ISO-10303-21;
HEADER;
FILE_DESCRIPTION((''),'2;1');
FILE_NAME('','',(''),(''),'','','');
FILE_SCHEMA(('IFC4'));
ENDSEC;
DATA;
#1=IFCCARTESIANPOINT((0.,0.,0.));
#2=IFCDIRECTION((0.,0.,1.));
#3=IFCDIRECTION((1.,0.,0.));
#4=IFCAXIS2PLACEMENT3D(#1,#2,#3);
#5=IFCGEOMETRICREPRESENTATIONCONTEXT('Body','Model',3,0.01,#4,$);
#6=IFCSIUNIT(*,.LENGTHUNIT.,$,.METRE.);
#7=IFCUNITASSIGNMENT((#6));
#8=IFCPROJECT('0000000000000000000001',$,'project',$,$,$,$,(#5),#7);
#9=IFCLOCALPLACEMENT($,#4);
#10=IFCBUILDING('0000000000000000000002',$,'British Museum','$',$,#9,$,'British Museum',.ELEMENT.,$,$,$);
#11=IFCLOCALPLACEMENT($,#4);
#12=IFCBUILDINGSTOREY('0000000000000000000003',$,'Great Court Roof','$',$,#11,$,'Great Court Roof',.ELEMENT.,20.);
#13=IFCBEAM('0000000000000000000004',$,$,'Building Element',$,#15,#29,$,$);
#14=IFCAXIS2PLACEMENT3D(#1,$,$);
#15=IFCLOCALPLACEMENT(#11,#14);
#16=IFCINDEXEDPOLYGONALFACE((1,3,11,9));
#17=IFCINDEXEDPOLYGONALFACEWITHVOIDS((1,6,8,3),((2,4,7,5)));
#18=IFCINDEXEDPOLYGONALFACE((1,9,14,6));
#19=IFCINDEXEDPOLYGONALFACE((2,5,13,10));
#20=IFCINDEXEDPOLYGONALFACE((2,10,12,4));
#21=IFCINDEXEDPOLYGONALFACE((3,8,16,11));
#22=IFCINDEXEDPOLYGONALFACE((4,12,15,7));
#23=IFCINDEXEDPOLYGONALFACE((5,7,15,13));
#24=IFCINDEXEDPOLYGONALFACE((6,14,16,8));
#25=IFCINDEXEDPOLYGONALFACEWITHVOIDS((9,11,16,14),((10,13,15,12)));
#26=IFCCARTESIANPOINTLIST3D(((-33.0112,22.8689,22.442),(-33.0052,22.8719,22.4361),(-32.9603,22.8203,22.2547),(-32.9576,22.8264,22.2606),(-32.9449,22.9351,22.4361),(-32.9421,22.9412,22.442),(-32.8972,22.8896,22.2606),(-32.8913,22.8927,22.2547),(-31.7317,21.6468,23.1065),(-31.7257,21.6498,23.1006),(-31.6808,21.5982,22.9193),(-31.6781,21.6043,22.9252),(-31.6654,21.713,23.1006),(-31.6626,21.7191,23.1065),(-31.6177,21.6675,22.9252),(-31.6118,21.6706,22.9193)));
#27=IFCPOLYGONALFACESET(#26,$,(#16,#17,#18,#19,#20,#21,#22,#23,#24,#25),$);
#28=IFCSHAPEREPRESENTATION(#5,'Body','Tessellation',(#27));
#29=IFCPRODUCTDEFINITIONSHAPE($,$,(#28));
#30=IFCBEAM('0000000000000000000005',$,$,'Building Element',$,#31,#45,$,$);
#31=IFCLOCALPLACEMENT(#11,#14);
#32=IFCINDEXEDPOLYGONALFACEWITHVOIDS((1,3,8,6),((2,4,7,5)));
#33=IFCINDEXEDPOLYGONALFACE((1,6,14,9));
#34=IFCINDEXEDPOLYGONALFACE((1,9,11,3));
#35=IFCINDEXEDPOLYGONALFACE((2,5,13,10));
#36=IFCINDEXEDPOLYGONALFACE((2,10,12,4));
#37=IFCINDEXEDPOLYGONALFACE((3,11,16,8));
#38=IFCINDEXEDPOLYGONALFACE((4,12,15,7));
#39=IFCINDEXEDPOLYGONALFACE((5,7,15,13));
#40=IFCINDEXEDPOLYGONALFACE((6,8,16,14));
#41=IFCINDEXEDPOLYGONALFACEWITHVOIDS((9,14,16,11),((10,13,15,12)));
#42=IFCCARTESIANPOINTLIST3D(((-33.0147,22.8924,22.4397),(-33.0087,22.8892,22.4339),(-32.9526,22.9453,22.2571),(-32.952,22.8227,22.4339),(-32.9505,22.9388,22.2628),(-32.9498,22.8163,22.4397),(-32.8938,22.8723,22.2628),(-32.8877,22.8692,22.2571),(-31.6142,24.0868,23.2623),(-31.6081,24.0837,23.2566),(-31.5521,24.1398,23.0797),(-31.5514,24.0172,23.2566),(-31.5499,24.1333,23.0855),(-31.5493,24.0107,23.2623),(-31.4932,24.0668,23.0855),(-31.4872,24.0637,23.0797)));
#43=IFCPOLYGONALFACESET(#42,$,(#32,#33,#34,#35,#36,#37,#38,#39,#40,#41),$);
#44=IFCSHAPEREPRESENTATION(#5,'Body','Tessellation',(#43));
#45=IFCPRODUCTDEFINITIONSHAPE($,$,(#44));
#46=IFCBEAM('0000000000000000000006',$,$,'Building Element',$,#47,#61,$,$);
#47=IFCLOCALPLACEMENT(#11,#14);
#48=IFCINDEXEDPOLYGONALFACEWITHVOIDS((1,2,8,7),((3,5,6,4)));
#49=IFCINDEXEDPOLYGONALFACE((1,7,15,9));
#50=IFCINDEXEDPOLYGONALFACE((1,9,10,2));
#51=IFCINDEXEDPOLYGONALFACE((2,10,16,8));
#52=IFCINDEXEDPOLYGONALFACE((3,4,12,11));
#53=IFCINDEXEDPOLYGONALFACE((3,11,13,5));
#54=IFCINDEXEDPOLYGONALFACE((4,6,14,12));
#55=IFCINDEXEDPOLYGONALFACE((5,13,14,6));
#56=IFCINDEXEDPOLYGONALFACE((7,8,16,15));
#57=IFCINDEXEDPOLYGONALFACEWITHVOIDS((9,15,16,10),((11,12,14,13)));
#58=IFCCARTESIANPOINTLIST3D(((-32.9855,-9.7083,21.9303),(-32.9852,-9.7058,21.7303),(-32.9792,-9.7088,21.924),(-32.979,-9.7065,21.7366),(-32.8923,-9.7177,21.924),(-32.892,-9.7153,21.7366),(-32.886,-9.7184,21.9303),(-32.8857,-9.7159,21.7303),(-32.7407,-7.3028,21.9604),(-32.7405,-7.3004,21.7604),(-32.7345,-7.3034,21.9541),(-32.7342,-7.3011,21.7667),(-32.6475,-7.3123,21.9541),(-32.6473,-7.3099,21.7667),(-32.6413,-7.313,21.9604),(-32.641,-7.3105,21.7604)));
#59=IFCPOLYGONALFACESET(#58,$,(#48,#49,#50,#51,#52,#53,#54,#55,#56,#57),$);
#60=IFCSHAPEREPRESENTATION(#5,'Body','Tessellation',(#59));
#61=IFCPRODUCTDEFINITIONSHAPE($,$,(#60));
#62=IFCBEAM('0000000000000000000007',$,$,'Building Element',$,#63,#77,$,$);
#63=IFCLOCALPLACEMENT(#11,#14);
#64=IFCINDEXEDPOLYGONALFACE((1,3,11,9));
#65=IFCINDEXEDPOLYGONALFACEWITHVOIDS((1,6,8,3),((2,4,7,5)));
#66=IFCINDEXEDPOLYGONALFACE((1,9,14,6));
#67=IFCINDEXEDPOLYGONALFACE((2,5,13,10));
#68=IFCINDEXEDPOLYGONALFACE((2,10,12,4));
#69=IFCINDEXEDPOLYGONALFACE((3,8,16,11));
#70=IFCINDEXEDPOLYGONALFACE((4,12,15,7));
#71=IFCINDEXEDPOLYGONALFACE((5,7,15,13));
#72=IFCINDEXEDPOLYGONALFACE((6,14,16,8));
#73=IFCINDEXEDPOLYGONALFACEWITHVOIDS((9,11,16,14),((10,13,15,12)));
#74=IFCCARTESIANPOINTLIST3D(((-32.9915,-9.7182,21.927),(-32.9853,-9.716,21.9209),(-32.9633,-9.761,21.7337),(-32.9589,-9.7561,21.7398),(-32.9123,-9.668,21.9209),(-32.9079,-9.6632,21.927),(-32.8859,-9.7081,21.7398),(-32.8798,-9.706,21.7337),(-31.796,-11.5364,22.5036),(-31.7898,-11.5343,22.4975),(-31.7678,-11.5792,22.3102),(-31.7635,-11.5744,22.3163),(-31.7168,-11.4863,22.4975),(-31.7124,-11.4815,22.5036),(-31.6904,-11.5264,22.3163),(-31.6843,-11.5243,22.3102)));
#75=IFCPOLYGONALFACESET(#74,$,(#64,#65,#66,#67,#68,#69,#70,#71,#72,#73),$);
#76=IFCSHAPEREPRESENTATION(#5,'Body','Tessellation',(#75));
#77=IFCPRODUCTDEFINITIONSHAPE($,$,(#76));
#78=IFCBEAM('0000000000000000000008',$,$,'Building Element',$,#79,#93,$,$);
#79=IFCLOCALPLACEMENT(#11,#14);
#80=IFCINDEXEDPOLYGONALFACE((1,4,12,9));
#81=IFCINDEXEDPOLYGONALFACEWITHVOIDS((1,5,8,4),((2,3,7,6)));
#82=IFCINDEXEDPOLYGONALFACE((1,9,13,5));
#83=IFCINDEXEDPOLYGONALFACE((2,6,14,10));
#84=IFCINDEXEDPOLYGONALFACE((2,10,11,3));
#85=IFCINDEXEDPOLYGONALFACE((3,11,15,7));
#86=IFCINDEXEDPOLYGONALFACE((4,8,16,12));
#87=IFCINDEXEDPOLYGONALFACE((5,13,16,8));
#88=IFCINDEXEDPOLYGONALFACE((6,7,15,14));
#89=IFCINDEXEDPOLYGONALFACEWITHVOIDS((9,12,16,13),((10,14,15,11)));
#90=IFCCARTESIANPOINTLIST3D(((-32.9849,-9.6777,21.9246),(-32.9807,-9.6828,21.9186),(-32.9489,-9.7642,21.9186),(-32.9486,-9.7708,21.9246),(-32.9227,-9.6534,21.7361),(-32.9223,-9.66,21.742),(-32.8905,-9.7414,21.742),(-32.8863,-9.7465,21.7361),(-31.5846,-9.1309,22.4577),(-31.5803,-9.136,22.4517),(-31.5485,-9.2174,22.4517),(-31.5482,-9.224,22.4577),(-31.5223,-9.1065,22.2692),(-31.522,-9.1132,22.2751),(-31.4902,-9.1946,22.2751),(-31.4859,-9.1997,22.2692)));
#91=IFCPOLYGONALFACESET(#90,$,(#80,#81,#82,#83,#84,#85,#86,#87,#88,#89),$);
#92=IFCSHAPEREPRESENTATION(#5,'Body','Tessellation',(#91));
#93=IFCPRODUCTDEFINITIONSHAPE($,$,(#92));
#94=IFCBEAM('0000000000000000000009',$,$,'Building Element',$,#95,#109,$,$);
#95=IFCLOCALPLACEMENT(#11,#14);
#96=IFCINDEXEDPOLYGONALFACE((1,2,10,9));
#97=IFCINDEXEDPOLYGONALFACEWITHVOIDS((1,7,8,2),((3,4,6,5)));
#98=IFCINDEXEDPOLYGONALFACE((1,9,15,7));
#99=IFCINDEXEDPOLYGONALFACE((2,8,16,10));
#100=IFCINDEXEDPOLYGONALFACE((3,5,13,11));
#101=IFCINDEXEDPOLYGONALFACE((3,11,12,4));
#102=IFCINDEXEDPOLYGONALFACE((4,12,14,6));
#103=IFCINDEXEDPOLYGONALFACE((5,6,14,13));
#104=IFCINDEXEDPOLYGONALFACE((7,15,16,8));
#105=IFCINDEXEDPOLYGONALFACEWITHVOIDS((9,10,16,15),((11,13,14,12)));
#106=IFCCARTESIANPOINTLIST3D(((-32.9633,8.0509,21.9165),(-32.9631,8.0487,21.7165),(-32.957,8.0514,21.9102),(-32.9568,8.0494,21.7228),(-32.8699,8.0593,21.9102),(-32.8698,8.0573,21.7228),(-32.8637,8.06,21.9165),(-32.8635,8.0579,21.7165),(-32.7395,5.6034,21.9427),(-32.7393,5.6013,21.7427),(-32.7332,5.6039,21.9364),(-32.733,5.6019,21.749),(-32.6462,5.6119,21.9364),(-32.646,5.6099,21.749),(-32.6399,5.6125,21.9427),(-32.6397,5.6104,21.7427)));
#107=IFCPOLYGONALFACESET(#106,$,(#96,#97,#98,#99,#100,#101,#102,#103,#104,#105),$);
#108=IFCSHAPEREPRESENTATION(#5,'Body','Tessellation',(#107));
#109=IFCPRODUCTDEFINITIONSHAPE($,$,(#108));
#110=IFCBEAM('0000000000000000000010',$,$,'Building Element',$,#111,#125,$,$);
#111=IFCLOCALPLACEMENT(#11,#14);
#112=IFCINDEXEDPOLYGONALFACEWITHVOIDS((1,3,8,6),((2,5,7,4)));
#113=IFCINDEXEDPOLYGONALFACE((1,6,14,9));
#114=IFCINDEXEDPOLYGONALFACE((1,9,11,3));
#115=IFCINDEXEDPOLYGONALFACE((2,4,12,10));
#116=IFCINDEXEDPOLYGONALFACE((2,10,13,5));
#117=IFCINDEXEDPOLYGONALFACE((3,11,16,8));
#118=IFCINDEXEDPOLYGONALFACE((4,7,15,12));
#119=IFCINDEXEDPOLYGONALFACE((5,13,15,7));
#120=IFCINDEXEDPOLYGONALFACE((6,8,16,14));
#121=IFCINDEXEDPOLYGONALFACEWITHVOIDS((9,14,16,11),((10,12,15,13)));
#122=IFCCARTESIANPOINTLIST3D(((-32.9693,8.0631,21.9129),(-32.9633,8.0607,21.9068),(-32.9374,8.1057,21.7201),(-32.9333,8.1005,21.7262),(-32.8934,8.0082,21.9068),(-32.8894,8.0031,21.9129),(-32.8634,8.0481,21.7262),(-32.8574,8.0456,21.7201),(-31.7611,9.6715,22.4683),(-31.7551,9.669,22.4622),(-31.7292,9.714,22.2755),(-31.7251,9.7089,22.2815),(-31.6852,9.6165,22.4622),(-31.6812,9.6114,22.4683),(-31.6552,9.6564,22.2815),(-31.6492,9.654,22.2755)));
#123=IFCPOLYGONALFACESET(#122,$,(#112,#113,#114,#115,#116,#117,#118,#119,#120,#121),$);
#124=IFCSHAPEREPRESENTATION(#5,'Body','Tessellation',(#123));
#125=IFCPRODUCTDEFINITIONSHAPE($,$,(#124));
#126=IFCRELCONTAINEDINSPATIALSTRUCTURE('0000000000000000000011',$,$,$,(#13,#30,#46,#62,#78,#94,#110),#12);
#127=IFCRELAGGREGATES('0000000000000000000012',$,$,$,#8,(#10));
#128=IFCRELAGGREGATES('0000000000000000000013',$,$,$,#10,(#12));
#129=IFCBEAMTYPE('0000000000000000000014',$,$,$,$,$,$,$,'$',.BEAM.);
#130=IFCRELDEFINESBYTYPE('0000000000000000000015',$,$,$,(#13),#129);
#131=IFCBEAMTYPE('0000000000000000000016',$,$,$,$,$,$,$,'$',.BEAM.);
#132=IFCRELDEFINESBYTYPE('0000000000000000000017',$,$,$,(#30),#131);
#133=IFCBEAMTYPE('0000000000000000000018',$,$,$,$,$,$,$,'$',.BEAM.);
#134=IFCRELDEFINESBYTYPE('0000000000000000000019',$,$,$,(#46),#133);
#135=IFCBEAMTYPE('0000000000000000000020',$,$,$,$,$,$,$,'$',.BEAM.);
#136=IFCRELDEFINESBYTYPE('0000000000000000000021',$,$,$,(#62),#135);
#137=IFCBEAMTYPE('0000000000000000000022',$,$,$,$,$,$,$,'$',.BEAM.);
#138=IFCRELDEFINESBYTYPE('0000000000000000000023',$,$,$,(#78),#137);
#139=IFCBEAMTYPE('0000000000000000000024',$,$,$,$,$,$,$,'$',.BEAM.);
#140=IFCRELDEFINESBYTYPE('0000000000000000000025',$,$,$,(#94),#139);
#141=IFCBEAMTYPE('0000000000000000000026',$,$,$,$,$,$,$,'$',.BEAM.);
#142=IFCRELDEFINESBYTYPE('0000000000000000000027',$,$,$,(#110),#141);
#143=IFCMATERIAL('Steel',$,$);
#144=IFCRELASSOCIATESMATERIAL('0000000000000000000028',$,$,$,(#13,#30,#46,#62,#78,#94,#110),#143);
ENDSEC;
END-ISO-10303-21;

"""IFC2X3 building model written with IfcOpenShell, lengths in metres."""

from ifc_helpers import new_model, si_unit, frame, origin_with_axes, origin_2d, place, context, project, spatial, hollow_rectangle, extrude, material, type_object, element, save


model = new_model("IFC2X3")

# Units and contexts
model_context = context("Model", 3, precision=0.01, world=origin_with_axes(), identifier="Body")
ifc_project = project(units=[si_unit("LENGTHUNIT", "METRE")], contexts=[model_context])

# Building, storey
building_placement = place(None, origin_with_axes())
building = spatial("IfcBuilding", under=ifc_project, at=building_placement, Name="British Museum", Description="$", LongName="British Museum", CompositionType="ELEMENT")
storey_placement = place(None, origin_with_axes())
storey = spatial("IfcBuildingStorey", under=building, at=storey_placement, Name="Great Court Roof", Description="$", LongName="Great Court Roof", CompositionType="ELEMENT", Elevation=20.0)

# Beams
ifc_material = material(Name="Steel")
beam_type_1 = type_object("IfcBeamType", ElementType="$", PredefinedType="BEAM")
beam_1_placement = place(None, origin_with_axes())
element("IfcBeam", 1, at=beam_1_placement, inside=storey, type_object=beam_type_1, material=ifc_material, Description="Building Element", context=model_context, shape_type="SweptSolid", body=[
    extrude(hollow_rectangle(XDim=0.1, YDim=0.2, WallThickness=0.0063, InnerFilletRadius=0.0, OuterFilletRadius=0.0, at=origin_2d()), frame((-32.9512, 22.8808, 22.3484), z_axis=(0.676973, -0.646596, 0.351598), x_axis=(0.690696, 0.723145, 0.0)), (0.0, 0.0, 1.0), 1.8901),
])
beam_type_2 = type_object("IfcBeamType", ElementType="$", PredefinedType="BEAM")
beam_2_placement = place(None, origin_with_axes())
element("IfcBeam", 2, at=beam_2_placement, inside=storey, type_object=beam_type_2, material=ifc_material, Description="Building Element", context=model_context, shape_type="SweptSolid", body=[
    extrude(hollow_rectangle(XDim=0.1, YDim=0.2, WallThickness=0.0063, InnerFilletRadius=0.0, OuterFilletRadius=0.0, at=origin_2d()), frame((-32.9512, 22.8808, 22.3484), z_axis=(0.694647, 0.592434, 0.408028), x_axis=(-0.648909, 0.760866, 0.0)), (0.0, 0.0, 1.0), 2.0162),
])
beam_type_3 = type_object("IfcBeamType", ElementType="$", PredefinedType="BEAM")
beam_3_placement = place(None, origin_with_axes())
element("IfcBeam", 3, at=beam_3_placement, inside=storey, type_object=beam_type_3, material=ifc_material, Description="Building Element", context=model_context, shape_type="SweptSolid", body=[
    extrude(hollow_rectangle(XDim=0.1, YDim=0.2, WallThickness=0.0063, InnerFilletRadius=0.0, OuterFilletRadius=0.0, at=origin_2d()), frame((-32.9356, -9.7121, 21.8303), z_axis=(0.101215, 0.994787, 0.012439), x_axis=(-0.994864, 0.101223, 0.0)), (0.0, 0.0, 1.0), 2.418),
])
beam_type_4 = type_object("IfcBeamType", ElementType="$", PredefinedType="BEAM")
beam_4_placement = place(None, origin_with_axes())
element("IfcBeam", 4, at=beam_4_placement, inside=storey, type_object=beam_type_4, material=ifc_material, Description="Building Element", context=model_context, shape_type="SweptSolid", body=[
    extrude(hollow_rectangle(XDim=0.1, YDim=0.2, WallThickness=0.0063, InnerFilletRadius=0.0, OuterFilletRadius=0.0, at=origin_2d()), frame((-32.9356, -9.7121, 21.8303), z_axis=(0.531054, -0.807701, 0.256127), x_axis=(0.835573, 0.54938, 0.0)), (0.0, 0.0, 1.0), 2.2511),
])
beam_type_5 = type_object("IfcBeamType", ElementType="$", PredefinedType="BEAM")
beam_5_placement = place(None, origin_with_axes())
element("IfcBeam", 5, at=beam_5_placement, inside=storey, type_object=beam_type_5, material=ifc_material, Description="Building Element", context=model_context, shape_type="SweptSolid", body=[
    extrude(hollow_rectangle(XDim=0.1, YDim=0.2, WallThickness=0.0063, InnerFilletRadius=0.0, OuterFilletRadius=0.0, at=origin_2d()), frame((-32.9356, -9.7121, 21.8303), z_axis=(0.877943, 0.342811, 0.334211), x_axis=(-0.363726, 0.931506, 0.0)), (0.0, 0.0, 1.0), 1.5951),
])
beam_type_6 = type_object("IfcBeamType", ElementType="$", PredefinedType="BEAM")
beam_6_placement = place(None, origin_with_axes())
element("IfcBeam", 6, at=beam_6_placement, inside=storey, type_object=beam_type_6, material=ifc_material, Description="Building Element", context=model_context, shape_type="SweptSolid", body=[
    extrude(hollow_rectangle(XDim=0.1, YDim=0.2, WallThickness=0.0063, InnerFilletRadius=0.0, OuterFilletRadius=0.0, at=origin_2d()), frame((-32.9134, 8.0544, 21.8165), z_axis=(0.09104, -0.99579, 0.010664), x_axis=(0.995847, 0.091045, 0.0)), (0.0, 0.0, 1.0), 2.4578),
])
beam_type_7 = type_object("IfcBeamType", ElementType="$", PredefinedType="BEAM")
beam_7_placement = place(None, origin_with_axes())
element("IfcBeam", 7, at=beam_7_placement, inside=storey, type_object=beam_type_7, material=ifc_material, Description="Building Element", context=model_context, shape_type="SweptSolid", body=[
    extrude(hollow_rectangle(XDim=0.1, YDim=0.2, WallThickness=0.0063, InnerFilletRadius=0.0, OuterFilletRadius=0.0, at=origin_2d()), frame((-32.9134, 8.0544, 21.8165), z_axis=(0.578953, 0.770708, 0.266126), x_axis=(-0.79954, 0.600613, 0.0)), (0.0, 0.0, 1.0), 2.0869),
])

save(model, "model.ifc")
